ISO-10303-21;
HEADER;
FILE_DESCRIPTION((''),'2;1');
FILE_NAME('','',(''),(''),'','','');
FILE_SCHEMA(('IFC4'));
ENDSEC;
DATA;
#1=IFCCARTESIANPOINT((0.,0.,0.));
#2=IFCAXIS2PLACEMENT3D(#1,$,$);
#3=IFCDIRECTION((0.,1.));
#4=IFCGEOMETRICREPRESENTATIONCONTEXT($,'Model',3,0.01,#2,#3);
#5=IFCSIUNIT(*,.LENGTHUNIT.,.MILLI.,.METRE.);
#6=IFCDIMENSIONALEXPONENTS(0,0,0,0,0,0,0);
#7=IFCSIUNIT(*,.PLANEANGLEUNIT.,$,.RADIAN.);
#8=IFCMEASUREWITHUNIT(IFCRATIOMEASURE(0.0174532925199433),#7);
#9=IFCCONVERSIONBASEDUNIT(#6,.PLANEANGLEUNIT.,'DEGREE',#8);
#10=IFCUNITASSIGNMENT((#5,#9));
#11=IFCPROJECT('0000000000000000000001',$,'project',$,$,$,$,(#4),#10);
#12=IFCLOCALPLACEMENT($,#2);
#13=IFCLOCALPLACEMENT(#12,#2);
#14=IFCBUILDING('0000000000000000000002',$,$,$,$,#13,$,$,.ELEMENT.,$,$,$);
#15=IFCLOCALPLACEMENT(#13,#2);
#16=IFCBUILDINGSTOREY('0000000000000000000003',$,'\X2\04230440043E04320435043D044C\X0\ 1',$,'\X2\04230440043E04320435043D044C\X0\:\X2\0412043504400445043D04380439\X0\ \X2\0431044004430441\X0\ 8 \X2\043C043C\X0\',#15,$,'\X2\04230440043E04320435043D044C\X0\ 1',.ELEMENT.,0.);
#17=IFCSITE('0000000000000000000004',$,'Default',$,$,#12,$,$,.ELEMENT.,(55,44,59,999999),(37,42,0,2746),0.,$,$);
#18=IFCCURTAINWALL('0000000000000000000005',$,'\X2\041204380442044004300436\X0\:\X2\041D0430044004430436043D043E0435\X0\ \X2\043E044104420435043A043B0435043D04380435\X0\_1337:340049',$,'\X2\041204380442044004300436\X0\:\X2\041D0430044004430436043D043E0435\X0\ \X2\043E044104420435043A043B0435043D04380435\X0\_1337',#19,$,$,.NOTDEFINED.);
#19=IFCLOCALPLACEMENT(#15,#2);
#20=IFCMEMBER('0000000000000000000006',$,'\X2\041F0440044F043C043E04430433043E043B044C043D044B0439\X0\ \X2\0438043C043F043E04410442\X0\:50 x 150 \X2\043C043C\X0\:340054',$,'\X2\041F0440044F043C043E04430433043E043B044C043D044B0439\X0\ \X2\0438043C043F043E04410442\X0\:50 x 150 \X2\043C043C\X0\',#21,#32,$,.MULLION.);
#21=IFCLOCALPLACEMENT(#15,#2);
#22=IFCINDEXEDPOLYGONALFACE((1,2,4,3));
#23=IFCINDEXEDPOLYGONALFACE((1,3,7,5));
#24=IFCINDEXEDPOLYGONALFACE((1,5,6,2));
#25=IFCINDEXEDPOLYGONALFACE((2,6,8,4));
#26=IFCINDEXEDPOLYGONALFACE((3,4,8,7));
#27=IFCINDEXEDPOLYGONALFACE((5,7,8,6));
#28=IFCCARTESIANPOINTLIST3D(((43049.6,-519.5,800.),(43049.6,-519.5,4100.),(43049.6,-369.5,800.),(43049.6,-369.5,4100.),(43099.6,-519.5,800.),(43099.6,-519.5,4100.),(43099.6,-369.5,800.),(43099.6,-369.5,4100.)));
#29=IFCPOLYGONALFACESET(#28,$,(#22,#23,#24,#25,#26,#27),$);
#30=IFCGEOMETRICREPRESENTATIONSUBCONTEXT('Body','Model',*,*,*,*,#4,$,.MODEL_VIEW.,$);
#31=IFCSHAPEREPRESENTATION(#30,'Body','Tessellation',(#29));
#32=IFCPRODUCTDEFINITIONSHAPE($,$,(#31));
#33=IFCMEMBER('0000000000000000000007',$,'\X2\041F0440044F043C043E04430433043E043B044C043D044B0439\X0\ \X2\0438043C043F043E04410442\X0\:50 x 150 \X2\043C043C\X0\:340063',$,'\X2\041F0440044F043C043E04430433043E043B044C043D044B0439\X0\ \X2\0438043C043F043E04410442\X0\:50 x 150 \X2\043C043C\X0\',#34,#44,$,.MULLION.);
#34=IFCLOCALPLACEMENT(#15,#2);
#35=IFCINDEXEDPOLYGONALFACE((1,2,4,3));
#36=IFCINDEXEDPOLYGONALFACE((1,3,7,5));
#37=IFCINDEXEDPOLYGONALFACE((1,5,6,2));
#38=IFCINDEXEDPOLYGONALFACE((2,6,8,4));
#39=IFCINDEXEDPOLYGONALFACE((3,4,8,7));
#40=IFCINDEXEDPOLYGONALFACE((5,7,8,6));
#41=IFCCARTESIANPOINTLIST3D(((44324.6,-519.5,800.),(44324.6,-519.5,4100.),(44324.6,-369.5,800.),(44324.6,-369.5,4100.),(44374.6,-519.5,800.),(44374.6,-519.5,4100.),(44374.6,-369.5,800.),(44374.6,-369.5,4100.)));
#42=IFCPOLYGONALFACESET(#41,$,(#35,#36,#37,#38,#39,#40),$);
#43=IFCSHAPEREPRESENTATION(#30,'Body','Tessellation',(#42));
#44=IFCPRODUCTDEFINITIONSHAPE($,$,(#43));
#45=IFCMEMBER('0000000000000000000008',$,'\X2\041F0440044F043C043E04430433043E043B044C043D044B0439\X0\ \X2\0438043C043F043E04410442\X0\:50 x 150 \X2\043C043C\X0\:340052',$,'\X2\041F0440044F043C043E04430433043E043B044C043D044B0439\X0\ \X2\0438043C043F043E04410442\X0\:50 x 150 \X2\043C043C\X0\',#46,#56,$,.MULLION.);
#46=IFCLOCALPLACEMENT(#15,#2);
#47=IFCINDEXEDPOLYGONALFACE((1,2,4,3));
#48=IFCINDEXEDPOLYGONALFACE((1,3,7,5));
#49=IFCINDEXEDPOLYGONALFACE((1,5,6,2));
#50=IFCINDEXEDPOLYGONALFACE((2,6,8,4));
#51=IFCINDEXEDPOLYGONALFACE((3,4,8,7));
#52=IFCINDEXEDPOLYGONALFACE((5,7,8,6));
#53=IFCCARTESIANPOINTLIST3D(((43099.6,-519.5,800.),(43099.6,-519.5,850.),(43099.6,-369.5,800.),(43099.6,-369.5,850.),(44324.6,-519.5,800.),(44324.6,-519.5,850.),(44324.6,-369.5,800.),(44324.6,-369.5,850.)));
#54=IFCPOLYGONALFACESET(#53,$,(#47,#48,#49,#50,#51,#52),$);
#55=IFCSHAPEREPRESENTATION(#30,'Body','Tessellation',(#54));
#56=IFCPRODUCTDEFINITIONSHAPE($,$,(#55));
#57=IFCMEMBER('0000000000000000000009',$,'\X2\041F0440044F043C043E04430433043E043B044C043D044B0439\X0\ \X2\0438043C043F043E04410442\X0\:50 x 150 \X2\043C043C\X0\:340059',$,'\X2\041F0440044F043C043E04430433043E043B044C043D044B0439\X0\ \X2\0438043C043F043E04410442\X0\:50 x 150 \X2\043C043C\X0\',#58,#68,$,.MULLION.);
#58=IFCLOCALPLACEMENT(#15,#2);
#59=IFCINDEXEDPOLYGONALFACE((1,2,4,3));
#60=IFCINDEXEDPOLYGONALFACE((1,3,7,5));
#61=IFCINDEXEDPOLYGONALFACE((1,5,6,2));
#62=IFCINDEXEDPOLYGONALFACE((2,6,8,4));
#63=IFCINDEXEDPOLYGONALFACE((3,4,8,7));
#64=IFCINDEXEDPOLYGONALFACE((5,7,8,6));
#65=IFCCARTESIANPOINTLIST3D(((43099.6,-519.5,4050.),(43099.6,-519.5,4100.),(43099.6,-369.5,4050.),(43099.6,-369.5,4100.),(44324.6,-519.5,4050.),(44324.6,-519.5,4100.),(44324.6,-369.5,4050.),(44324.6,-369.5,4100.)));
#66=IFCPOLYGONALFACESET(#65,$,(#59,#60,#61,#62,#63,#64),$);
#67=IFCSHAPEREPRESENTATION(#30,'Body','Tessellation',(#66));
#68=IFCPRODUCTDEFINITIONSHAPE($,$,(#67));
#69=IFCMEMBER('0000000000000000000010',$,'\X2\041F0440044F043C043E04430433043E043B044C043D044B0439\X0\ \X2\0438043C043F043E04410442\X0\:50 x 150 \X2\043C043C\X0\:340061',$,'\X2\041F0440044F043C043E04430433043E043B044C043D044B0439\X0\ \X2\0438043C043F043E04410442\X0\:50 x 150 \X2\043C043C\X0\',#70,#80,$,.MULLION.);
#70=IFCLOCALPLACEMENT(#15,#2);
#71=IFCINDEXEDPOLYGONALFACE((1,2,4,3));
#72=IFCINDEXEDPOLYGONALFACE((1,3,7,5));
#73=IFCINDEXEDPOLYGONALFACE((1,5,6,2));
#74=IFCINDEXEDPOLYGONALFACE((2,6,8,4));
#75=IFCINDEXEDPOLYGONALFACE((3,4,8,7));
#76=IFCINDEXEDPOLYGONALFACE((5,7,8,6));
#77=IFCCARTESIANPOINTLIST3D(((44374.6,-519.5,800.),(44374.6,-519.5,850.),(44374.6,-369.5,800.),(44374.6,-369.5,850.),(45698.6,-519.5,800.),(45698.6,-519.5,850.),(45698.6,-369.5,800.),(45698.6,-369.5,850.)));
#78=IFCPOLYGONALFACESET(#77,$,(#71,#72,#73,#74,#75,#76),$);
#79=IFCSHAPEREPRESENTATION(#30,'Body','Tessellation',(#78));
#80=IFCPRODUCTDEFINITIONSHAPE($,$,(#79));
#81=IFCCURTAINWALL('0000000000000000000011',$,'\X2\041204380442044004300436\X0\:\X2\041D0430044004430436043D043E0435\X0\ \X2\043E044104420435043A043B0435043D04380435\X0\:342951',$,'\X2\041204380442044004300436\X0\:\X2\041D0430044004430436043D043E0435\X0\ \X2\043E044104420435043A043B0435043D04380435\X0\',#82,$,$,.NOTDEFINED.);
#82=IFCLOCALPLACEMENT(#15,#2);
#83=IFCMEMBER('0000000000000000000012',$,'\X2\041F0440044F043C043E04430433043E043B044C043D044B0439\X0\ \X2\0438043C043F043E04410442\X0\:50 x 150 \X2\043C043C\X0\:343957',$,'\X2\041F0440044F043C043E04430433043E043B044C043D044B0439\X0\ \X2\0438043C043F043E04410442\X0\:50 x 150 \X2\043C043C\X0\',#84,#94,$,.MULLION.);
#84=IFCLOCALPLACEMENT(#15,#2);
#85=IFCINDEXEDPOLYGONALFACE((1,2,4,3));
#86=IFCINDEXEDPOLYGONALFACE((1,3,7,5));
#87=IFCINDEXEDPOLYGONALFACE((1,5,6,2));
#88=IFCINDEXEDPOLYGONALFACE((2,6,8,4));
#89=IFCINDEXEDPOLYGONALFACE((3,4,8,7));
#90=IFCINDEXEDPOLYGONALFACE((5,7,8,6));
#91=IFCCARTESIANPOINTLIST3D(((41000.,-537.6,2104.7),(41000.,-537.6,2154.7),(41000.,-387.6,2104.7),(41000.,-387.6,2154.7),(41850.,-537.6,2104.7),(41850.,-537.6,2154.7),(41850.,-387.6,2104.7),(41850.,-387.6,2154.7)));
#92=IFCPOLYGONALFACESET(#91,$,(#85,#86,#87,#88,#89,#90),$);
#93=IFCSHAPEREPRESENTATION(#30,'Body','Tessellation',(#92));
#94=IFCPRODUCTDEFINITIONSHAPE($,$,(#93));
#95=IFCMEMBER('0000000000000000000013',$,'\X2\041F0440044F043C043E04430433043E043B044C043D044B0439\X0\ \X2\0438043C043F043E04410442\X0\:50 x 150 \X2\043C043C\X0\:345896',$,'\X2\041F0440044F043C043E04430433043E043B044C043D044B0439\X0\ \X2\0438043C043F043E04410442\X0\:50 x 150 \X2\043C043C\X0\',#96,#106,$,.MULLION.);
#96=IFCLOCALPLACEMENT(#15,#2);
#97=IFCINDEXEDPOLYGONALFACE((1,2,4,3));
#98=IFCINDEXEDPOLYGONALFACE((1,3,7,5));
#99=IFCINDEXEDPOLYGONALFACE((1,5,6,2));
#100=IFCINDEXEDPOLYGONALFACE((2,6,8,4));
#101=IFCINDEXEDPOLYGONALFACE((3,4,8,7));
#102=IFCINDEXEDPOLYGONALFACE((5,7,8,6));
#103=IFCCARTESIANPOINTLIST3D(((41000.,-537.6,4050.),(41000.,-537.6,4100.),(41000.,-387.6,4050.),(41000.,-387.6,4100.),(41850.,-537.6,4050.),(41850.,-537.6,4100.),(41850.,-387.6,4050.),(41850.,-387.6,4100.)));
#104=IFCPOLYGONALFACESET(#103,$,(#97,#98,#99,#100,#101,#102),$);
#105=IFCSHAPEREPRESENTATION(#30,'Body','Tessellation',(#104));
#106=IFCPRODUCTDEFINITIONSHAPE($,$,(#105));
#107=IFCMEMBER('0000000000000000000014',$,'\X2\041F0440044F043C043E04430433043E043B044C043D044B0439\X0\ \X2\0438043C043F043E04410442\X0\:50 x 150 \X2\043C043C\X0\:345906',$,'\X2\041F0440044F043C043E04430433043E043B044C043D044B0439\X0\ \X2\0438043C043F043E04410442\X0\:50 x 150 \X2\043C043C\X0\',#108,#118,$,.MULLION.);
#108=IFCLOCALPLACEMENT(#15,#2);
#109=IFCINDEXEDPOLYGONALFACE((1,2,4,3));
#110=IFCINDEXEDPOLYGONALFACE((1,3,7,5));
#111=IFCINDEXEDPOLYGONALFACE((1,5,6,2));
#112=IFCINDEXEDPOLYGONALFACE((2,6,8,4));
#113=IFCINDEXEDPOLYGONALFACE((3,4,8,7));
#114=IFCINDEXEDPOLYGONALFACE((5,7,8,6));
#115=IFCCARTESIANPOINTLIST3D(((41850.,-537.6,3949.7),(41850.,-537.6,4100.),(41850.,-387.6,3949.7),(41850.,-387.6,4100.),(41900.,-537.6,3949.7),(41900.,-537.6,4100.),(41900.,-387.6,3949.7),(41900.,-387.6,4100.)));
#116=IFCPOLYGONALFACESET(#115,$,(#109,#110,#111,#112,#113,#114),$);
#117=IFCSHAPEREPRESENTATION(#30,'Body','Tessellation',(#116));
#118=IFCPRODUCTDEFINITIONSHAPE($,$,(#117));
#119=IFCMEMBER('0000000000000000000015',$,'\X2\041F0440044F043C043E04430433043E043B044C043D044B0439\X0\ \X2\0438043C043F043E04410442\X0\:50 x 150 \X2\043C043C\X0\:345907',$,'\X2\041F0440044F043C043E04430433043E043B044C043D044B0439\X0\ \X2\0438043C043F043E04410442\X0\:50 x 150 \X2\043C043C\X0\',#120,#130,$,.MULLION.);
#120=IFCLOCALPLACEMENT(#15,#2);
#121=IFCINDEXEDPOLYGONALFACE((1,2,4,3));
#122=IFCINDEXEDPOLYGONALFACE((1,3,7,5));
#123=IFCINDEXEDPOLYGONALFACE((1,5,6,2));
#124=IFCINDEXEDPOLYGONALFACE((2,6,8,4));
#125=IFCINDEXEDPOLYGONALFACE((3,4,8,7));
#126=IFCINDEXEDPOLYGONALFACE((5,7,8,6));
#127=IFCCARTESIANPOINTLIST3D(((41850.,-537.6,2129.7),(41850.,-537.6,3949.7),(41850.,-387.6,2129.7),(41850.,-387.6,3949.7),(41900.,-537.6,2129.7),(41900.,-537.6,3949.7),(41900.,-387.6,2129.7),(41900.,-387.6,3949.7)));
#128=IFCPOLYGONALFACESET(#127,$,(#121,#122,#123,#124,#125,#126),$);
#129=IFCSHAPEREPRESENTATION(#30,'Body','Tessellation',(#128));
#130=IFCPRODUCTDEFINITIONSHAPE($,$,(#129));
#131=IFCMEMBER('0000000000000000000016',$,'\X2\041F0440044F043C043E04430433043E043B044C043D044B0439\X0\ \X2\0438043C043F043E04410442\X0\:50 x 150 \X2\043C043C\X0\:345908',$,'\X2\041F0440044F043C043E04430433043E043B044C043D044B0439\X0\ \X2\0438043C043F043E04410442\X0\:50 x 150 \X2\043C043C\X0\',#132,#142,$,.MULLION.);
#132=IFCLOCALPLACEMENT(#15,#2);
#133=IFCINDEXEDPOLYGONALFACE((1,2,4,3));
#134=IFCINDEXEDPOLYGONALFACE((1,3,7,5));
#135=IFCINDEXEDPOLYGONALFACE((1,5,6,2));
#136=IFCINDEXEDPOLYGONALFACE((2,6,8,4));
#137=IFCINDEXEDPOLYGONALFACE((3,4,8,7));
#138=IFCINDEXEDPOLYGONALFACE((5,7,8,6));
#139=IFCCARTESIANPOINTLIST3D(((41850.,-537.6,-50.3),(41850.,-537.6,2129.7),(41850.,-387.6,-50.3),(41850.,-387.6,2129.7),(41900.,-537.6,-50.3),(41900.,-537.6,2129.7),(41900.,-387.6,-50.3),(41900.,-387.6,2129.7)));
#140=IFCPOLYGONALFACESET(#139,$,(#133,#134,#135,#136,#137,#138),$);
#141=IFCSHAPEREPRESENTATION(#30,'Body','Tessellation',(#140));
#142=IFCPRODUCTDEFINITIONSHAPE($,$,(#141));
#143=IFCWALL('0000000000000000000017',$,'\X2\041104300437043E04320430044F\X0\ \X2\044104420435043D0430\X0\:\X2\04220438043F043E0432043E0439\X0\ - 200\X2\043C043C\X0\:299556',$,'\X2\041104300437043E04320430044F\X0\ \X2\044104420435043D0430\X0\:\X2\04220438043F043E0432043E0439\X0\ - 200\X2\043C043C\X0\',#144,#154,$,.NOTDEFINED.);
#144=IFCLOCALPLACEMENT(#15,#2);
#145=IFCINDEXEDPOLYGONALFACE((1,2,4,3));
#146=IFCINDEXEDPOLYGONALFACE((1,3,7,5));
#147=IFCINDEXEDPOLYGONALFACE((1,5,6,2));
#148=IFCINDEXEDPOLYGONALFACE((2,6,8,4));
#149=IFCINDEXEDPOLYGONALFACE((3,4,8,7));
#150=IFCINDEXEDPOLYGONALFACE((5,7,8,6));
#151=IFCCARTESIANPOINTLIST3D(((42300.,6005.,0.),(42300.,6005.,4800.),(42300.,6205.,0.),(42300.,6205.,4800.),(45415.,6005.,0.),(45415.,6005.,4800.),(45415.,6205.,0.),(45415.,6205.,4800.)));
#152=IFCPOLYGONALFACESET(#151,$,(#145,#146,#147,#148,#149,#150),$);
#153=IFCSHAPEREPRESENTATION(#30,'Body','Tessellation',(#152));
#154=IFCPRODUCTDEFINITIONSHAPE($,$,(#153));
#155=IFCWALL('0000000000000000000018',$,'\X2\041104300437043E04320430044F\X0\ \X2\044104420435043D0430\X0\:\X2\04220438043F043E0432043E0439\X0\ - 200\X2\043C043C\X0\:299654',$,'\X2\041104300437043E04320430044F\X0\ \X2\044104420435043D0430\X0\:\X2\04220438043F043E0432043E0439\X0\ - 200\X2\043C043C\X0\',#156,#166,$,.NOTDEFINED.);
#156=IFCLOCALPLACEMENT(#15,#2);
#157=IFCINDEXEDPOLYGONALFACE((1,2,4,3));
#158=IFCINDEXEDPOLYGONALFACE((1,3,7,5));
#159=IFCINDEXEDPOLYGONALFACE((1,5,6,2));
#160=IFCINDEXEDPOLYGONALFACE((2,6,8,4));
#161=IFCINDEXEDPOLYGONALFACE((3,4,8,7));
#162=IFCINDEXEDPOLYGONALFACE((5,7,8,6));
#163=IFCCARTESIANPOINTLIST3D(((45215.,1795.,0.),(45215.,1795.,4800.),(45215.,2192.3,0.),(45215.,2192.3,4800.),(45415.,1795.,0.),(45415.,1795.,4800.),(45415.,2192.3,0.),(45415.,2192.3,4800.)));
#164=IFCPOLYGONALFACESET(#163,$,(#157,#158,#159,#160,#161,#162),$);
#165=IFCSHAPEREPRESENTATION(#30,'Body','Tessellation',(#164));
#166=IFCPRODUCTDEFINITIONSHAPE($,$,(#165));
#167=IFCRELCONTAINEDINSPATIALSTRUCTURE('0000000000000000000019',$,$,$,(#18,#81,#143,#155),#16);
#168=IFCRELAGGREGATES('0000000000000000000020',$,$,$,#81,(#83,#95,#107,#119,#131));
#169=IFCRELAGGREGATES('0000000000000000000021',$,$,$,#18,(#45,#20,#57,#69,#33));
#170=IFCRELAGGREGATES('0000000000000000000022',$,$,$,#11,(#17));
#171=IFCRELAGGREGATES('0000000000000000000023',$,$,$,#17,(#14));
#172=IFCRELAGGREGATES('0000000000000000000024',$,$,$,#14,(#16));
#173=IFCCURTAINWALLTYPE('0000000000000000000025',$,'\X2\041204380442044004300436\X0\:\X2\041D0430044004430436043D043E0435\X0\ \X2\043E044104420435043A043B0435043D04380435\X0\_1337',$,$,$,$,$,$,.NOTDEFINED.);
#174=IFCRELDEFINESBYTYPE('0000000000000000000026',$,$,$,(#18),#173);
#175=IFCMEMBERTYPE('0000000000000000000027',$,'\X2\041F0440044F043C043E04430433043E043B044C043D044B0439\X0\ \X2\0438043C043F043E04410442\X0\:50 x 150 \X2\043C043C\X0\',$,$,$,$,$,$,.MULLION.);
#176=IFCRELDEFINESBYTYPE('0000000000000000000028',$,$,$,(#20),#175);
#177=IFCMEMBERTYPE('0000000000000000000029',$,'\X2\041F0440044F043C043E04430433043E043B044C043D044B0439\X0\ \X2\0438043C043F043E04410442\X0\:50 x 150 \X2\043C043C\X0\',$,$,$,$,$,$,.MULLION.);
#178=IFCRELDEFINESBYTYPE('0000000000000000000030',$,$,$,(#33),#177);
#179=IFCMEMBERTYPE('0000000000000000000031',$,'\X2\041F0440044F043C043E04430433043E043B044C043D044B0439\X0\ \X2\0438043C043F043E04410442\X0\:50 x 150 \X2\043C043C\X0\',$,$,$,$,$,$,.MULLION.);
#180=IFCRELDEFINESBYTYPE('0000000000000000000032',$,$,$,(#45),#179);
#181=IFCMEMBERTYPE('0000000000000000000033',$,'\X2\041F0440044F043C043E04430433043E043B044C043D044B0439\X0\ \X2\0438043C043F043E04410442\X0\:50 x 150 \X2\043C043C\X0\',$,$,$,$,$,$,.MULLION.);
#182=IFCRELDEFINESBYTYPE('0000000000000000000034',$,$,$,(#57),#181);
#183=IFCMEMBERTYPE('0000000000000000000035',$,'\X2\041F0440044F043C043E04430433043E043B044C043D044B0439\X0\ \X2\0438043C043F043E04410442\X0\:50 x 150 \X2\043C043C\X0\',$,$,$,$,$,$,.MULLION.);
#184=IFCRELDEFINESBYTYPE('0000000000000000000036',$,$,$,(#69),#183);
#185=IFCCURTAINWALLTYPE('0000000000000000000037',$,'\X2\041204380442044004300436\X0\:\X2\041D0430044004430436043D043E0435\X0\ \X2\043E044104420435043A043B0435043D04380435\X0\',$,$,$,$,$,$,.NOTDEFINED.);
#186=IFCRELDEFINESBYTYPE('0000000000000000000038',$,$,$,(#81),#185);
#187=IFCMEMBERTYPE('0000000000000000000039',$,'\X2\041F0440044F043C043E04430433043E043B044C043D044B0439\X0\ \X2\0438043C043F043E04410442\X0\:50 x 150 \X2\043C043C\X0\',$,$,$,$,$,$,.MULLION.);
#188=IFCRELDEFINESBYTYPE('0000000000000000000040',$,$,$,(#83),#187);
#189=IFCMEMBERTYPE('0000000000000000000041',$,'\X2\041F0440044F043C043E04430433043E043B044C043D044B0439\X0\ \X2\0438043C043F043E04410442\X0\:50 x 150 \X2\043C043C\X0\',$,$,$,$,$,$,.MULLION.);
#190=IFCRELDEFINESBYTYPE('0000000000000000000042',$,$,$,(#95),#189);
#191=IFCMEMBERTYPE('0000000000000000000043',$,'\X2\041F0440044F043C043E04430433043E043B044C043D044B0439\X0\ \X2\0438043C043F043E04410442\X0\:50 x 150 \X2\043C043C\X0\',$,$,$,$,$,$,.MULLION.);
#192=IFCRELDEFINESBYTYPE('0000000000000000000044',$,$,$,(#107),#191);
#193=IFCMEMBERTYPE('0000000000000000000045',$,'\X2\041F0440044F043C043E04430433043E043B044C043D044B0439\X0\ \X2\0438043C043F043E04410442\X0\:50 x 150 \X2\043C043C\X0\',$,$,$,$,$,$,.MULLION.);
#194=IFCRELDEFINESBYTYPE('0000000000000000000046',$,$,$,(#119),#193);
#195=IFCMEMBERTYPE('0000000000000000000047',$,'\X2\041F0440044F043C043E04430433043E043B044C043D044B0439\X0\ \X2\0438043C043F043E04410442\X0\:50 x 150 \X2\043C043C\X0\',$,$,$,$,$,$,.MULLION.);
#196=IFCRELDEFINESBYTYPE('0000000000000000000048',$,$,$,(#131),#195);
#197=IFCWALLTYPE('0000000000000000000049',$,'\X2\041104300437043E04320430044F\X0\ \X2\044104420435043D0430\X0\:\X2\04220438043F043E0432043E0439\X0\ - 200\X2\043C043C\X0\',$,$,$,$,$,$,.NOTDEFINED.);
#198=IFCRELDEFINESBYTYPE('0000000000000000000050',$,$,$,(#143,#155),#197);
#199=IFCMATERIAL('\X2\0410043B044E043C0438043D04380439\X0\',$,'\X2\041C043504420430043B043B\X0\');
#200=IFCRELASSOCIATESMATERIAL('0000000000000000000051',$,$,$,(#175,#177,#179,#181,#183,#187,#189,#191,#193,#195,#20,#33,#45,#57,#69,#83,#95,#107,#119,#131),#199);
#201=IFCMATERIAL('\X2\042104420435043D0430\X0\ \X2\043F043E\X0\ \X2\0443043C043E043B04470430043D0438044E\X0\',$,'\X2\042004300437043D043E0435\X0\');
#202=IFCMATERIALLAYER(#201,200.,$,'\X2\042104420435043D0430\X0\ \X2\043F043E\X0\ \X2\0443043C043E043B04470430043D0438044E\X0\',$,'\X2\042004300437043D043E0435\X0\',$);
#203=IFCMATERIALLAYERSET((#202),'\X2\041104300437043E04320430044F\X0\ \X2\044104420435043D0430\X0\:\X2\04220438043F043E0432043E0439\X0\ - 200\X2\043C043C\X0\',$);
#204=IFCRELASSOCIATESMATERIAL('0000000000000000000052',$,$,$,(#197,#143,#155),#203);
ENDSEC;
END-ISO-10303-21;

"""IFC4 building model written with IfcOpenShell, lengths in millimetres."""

from ifc_helpers import new_model, entity, si_unit, converted_unit, direction, frame, frame_2d, origin, origin_2d_with_axis, place, context, subcontext, project, spatial, rectangle, extrude, source, transform, mapped, material, layer, layer_set, layer_usage, material_profile, profile_set, profile_usage, type_object, type_shapes, element, aggregate, save


model = new_model("IFC4")

# Units and contexts
model_context = context("Model", 3, precision=0.01, world=origin(), true_north=direction((0.0, 1.0)))
body_context = subcontext(model_context, "Body", "Model", "MODEL_VIEW")
ifc_project = project(units=[si_unit("LENGTHUNIT", "METRE", prefix="MILLI"), converted_unit("PLANEANGLEUNIT", "DEGREE", entity("IfcRatioMeasure", 0.0174532925199433), si_unit("PLANEANGLEUNIT", "RADIAN"), dimensions=[0, 0, 0, 0, 0, 0, 0])], contexts=[model_context])

# Site, building, storey
site_placement = place(None, origin())
site = spatial("IfcSite", under=ifc_project, at=site_placement, Name="Default", CompositionType="ELEMENT", RefLatitude=(55, 44, 59, 999999), RefLongitude=(37, 42, 0, 2746), RefElevation=0.0)
building_placement = place(site_placement, origin())
building = spatial("IfcBuilding", under=site, at=building_placement, CompositionType="ELEMENT")
storey_placement = place(building_placement, origin())
storey = spatial("IfcBuildingStorey", under=building, at=storey_placement, Name="Уровень 1", ObjectType="Уровень:Верхний брус 8 мм", LongName="Уровень 1", CompositionType="ELEMENT", Elevation=0.0)

# Curtain walls, members
curtain_wall_type_1 = type_object("IfcCurtainWallType", Name="Витраж:Наружное остекление_1337", PredefinedType="NOTDEFINED")
curtain_wall_1_placement = place(storey_placement, origin())
curtain_wall_1 = element("IfcCurtainWall", 1, at=curtain_wall_1_placement, inside=storey, type_object=curtain_wall_type_1, Name="Витраж:Наружное остекление_1337:340049", ObjectType="Витраж:Наружное остекление_1337", PredefinedType="NOTDEFINED")
ifc_material_1 = material(Name="Алюминий", Category="Металл")
ifc_material_profile = material_profile(ifc_material_1, rectangle(XDim=150.0, YDim=50.0, at=origin_2d_with_axis()), Name="50 x 150 мм")
ifc_profile_set = profile_set([ifc_material_profile], Name="50 x 150 мм")
ifc_profile_usage_1 = profile_usage(ifc_profile_set)
member_type_1 = type_object("IfcMemberType", Name="Прямоугольный импост:50 x 150 мм", PredefinedType="MULLION", material=ifc_profile_set)
shared_shape_1 = source(origin(), body_context, "Body", "SweptSolid", [
    extrude(rectangle(XDim=150.0, YDim=50.0, at=origin_2d_with_axis()), frame((-25.0, 0.0, -3300.0), z_axis=(0.0, 0.0, 1.0), x_axis=(0.0, -1.0, 0.0)), (0.0, 0.0, 1.0), 3300.0),
])
type_shapes(member_type_1, [shared_shape_1])
member_1_placement = place(storey_placement, frame((43049.6, -444.5, 4100.0), z_axis=(0.0, 0.0, 1.0), x_axis=(-1.0, 0.0, 0.0)))
member_1 = element("IfcMember", 2, at=member_1_placement, type_object=member_type_1, material=ifc_profile_usage_1, Name="Прямоугольный импост:50 x 150 мм:340054", ObjectType="Прямоугольный импост:50 x 150 мм", PredefinedType="MULLION", context=body_context, shape_type="MappedRepresentation", body=[
    mapped(shared_shape_1, transform((0.0, 0.0, 0.0), scale=1.0)),
])
ifc_profile_usage_2 = profile_usage(ifc_profile_set)
member_type_2 = type_object("IfcMemberType", Name="Прямоугольный импост:50 x 150 мм", PredefinedType="MULLION", material=ifc_profile_set)
shared_shape_2 = source(origin(), body_context, "Body", "SweptSolid", [
    extrude(rectangle(XDim=150.0, YDim=50.0, at=origin_2d_with_axis()), frame((0.0, 0.0, -3300.0), z_axis=(0.0, 0.0, 1.0), x_axis=(0.0, -1.0, 0.0)), (0.0, 0.0, 1.0), 3300.0),
])
type_shapes(member_type_2, [shared_shape_2])
member_2_placement = place(storey_placement, frame((44349.6, -444.5, 800.0), z_axis=(0.0, 0.0, -1.0), x_axis=(1.0, 0.0, 0.0)))
member_2 = element("IfcMember", 3, at=member_2_placement, type_object=member_type_2, material=ifc_profile_usage_2, Name="Прямоугольный импост:50 x 150 мм:340063", ObjectType="Прямоугольный импост:50 x 150 мм", PredefinedType="MULLION", context=body_context, shape_type="MappedRepresentation", body=[
    mapped(shared_shape_2, transform((0.0, 0.0, 0.0), scale=1.0)),
])
ifc_profile_usage_3 = profile_usage(ifc_profile_set)
member_type_3 = type_object("IfcMemberType", Name="Прямоугольный импост:50 x 150 мм", PredefinedType="MULLION", material=ifc_profile_set)
shared_shape_3 = source(origin(), body_context, "Body", "SweptSolid", [
    extrude(rectangle(XDim=150.0, YDim=50.0, at=origin_2d_with_axis()), frame((-25.0, 0.0, -1225.0), z_axis=(0.0, 0.0, 1.0), x_axis=(0.0, -1.0, 0.0)), (0.0, 0.0, 1.0), 1225.0),
])
type_shapes(member_type_3, [shared_shape_3])
member_3_placement = place(storey_placement, frame((43099.6, -444.5, 800.0), z_axis=(-1.0, 0.0, 0.0), x_axis=(0.0, 0.0, -1.0)))
member_3 = element("IfcMember", 4, at=member_3_placement, type_object=member_type_3, material=ifc_profile_usage_3, Name="Прямоугольный импост:50 x 150 мм:340052", ObjectType="Прямоугольный импост:50 x 150 мм", PredefinedType="MULLION", context=body_context, shape_type="MappedRepresentation", body=[
    mapped(shared_shape_3, transform((0.0, 0.0, 0.0), scale=1.0)),
])
ifc_profile_usage_4 = profile_usage(ifc_profile_set)
member_type_4 = type_object("IfcMemberType", Name="Прямоугольный импост:50 x 150 мм", PredefinedType="MULLION", material=ifc_profile_set)
shared_shape_4 = source(origin(), body_context, "Body", "SweptSolid", [
    extrude(rectangle(XDim=150.0, YDim=50.0, at=origin_2d_with_axis()), frame((-25.0, 0.0, -1225.0), z_axis=(0.0, 0.0, 1.0), x_axis=(0.0, -1.0, 0.0)), (0.0, 0.0, 1.0), 1225.0),
])
type_shapes(member_type_4, [shared_shape_4])
member_4_placement = place(storey_placement, frame((44324.6, -444.5, 4100.0), z_axis=(1.0, 0.0, 0.0), x_axis=(0.0, 0.0, 1.0)))
member_4 = element("IfcMember", 5, at=member_4_placement, type_object=member_type_4, material=ifc_profile_usage_4, Name="Прямоугольный импост:50 x 150 мм:340059", ObjectType="Прямоугольный импост:50 x 150 мм", PredefinedType="MULLION", context=body_context, shape_type="MappedRepresentation", body=[
    mapped(shared_shape_4, transform((0.0, 0.0, 0.0), scale=1.0)),
])
ifc_profile_usage_5 = profile_usage(ifc_profile_set)
member_type_5 = type_object("IfcMemberType", Name="Прямоугольный импост:50 x 150 мм", PredefinedType="MULLION", material=ifc_profile_set)
shared_shape_5 = source(origin(), body_context, "Body", "SweptSolid", [
    extrude(rectangle(XDim=150.0, YDim=50.0, at=origin_2d_with_axis()), frame((-25.0, 0.0, -1324.0), z_axis=(0.0, 0.0, 1.0), x_axis=(0.0, -1.0, 0.0)), (0.0, 0.0, 1.0), 1324.0),
])
type_shapes(member_type_5, [shared_shape_5])
member_5_placement = place(storey_placement, frame((44374.6, -444.5, 800.0), z_axis=(-1.0, 0.0, 0.0), x_axis=(0.0, 0.0, -1.0)))
member_5 = element("IfcMember", 6, at=member_5_placement, type_object=member_type_5, material=ifc_profile_usage_5, Name="Прямоугольный импост:50 x 150 мм:340061", ObjectType="Прямоугольный импост:50 x 150 мм", PredefinedType="MULLION", context=body_context, shape_type="MappedRepresentation", body=[
    mapped(shared_shape_5, transform((0.0, 0.0, 0.0), scale=1.0)),
])
curtain_wall_type_2 = type_object("IfcCurtainWallType", Name="Витраж:Наружное остекление", PredefinedType="NOTDEFINED")
curtain_wall_2_placement = place(storey_placement, origin())
curtain_wall_2 = element("IfcCurtainWall", 7, at=curtain_wall_2_placement, inside=storey, type_object=curtain_wall_type_2, Name="Витраж:Наружное остекление:342951", ObjectType="Витраж:Наружное остекление", PredefinedType="NOTDEFINED")
ifc_profile_usage_6 = profile_usage(ifc_profile_set)
member_type_6 = type_object("IfcMemberType", Name="Прямоугольный импост:50 x 150 мм", PredefinedType="MULLION", material=ifc_profile_set)
shared_shape_6 = source(origin(), body_context, "Body", "SweptSolid", [
    extrude(rectangle(XDim=150.0, YDim=50.0, at=origin_2d_with_axis()), frame((0.0, 0.0, -850.0), z_axis=(0.0, 0.0, 1.0), x_axis=(0.0, -1.0, 0.0)), (0.0, 0.0, 1.0), 850.0),
])
type_shapes(member_type_6, [shared_shape_6])
member_6_placement = place(storey_placement, frame((41850.0, -462.6, 2129.7), z_axis=(1.0, 0.0, 0.0), x_axis=(0.0, 0.0, 1.0)))
member_6 = element("IfcMember", 8, at=member_6_placement, type_object=member_type_6, material=ifc_profile_usage_6, Name="Прямоугольный импост:50 x 150 мм:343957", ObjectType="Прямоугольный импост:50 x 150 мм", PredefinedType="MULLION", context=body_context, shape_type="MappedRepresentation", body=[
    mapped(shared_shape_6, transform((0.0, 0.0, 0.0), scale=1.0)),
])
ifc_profile_usage_7 = profile_usage(ifc_profile_set)
member_type_7 = type_object("IfcMemberType", Name="Прямоугольный импост:50 x 150 мм", PredefinedType="MULLION", material=ifc_profile_set)
shared_shape_7 = source(origin(), body_context, "Body", "SweptSolid", [
    extrude(rectangle(XDim=150.0, YDim=50.0, at=origin_2d_with_axis()), frame((-25.0, 0.0, -850.0), z_axis=(0.0, 0.0, 1.0), x_axis=(0.0, -1.0, 0.0)), (0.0, 0.0, 1.0), 850.0),
])
type_shapes(member_type_7, [shared_shape_7])
member_7_placement = place(storey_placement, frame((41850.0, -462.6, 4100.0), z_axis=(1.0, 0.0, 0.0), x_axis=(0.0, 0.0, 1.0)))
member_7 = element("IfcMember", 9, at=member_7_placement, type_object=member_type_7, material=ifc_profile_usage_7, Name="Прямоугольный импост:50 x 150 мм:345896", ObjectType="Прямоугольный импост:50 x 150 мм", PredefinedType="MULLION", context=body_context, shape_type="MappedRepresentation", body=[
    mapped(shared_shape_7, transform((0.0, 0.0, 0.0), scale=1.0)),
])
ifc_profile_usage_8 = profile_usage(ifc_profile_set)
member_type_8 = type_object("IfcMemberType", Name="Прямоугольный импост:50 x 150 мм", PredefinedType="MULLION", material=ifc_profile_set)
shared_shape_8 = source(origin(), body_context, "Body", "SweptSolid", [
    extrude(rectangle(XDim=150.0, YDim=50.0, at=origin_2d_with_axis()), frame((-25.0, 0.0, -150.3), z_axis=(0.0, 0.0, 1.0), x_axis=(0.0, -1.0, 0.0)), (0.0, 0.0, 1.0), 150.3),
])
type_shapes(member_type_8, [shared_shape_8])
member_8_placement = place(storey_placement, frame((41900.0, -462.6, 3949.7), z_axis=(0.0, 0.0, -1.0), x_axis=(1.0, 0.0, 0.0)))
member_8 = element("IfcMember", 10, at=member_8_placement, type_object=member_type_8, material=ifc_profile_usage_8, Name="Прямоугольный импост:50 x 150 мм:345906", ObjectType="Прямоугольный импост:50 x 150 мм", PredefinedType="MULLION", context=body_context, shape_type="MappedRepresentation", body=[
    mapped(shared_shape_8, transform((0.0, 0.0, 0.0), scale=1.0)),
])
ifc_profile_usage_9 = profile_usage(ifc_profile_set)
member_type_9 = type_object("IfcMemberType", Name="Прямоугольный импост:50 x 150 мм", PredefinedType="MULLION", material=ifc_profile_set)
shared_shape_9 = source(origin(), body_context, "Body", "SweptSolid", [
    extrude(rectangle(XDim=150.0, YDim=50.0, at=origin_2d_with_axis()), frame((-25.0, 0.0, -1820.0), z_axis=(0.0, 0.0, 1.0), x_axis=(0.0, -1.0, 0.0)), (0.0, 0.0, 1.0), 1820.0),
])
type_shapes(member_type_9, [shared_shape_9])
member_9_placement = place(storey_placement, frame((41900.0, -462.6, 2129.7), z_axis=(0.0, 0.0, -1.0), x_axis=(1.0, 0.0, 0.0)))
member_9 = element("IfcMember", 11, at=member_9_placement, type_object=member_type_9, material=ifc_profile_usage_9, Name="Прямоугольный импост:50 x 150 мм:345907", ObjectType="Прямоугольный импост:50 x 150 мм", PredefinedType="MULLION", context=body_context, shape_type="MappedRepresentation", body=[
    mapped(shared_shape_9, transform((0.0, 0.0, 0.0), scale=1.0)),
])
ifc_profile_usage_10 = profile_usage(ifc_profile_set)
member_type_10 = type_object("IfcMemberType", Name="Прямоугольный импост:50 x 150 мм", PredefinedType="MULLION", material=ifc_profile_set)
shared_shape_10 = source(origin(), body_context, "Body", "SweptSolid", [
    extrude(rectangle(XDim=150.0, YDim=50.0, at=origin_2d_with_axis()), frame((-25.0, 0.0, -2180.0), z_axis=(0.0, 0.0, 1.0), x_axis=(0.0, -1.0, 0.0)), (0.0, 0.0, 1.0), 2180.0),
])
type_shapes(member_type_10, [shared_shape_10])
member_10_placement = place(storey_placement, frame((41900.0, -462.6, -50.3), z_axis=(0.0, 0.0, -1.0), x_axis=(1.0, 0.0, 0.0)))
member_10 = element("IfcMember", 12, at=member_10_placement, type_object=member_type_10, material=ifc_profile_usage_10, Name="Прямоугольный импост:50 x 150 мм:345908", ObjectType="Прямоугольный импост:50 x 150 мм", PredefinedType="MULLION", context=body_context, shape_type="MappedRepresentation", body=[
    mapped(shared_shape_10, transform((0.0, 0.0, 0.0), scale=1.0)),
])
aggregate(curtain_wall_2, [member_6, member_7, member_8, member_9, member_10])

aggregate(curtain_wall_1, [member_3, member_1, member_4, member_5, member_2])

# Wall
ifc_material_2 = material(Name="Стена по умолчанию", Category="Разное")
ifc_layer_1 = layer(ifc_material_2, 200.0, Name="Стена по умолчанию", Category="Разное")
ifc_layer_set_1 = layer_set([ifc_layer_1], Name="Базовая стена:Типовой - 200мм")
ifc_layer_usage_1 = layer_usage(ifc_layer_set_1, "AXIS2", "NEGATIVE", 100.0)
wall_type_1 = type_object("IfcWallType", Name="Базовая стена:Типовой - 200мм", PredefinedType="NOTDEFINED", material=ifc_layer_set_1)
wall_1_placement = place(storey_placement, frame((42300.0, 6105.0, 0.0)))
element("IfcWall", 13, at=wall_1_placement, inside=storey, type_object=wall_type_1, material=ifc_layer_usage_1, Name="Базовая стена:Типовой - 200мм:299556", ObjectType="Базовая стена:Типовой - 200мм", PredefinedType="NOTDEFINED", context=body_context, shape_type="SweptSolid", body=[
    extrude(rectangle(XDim=3115.0, YDim=200.0, at=frame_2d((1557.5, 0.0), x_axis=(-1.0, 0.0))), origin(), (0.0, 0.0, 1.0), 4800.0),
])

# Wall
ifc_layer_usage_2 = layer_usage(ifc_layer_set_1, "AXIS2", "NEGATIVE", 100.0)
wall_2_placement = place(storey_placement, frame((45315.0, 2192.3, 0.0), z_axis=(0.0, 0.0, 1.0), x_axis=(0.0, -1.0, 0.0)))
element("IfcWall", 14, at=wall_2_placement, inside=storey, type_object=wall_type_1, material=ifc_layer_usage_2, Name="Базовая стена:Типовой - 200мм:299654", ObjectType="Базовая стена:Типовой - 200мм", PredefinedType="NOTDEFINED", context=body_context, shape_type="SweptSolid", body=[
    extrude(rectangle(XDim=397.3, YDim=200.0, at=frame_2d((198.6, 0.0), x_axis=(-1.0, 0.0))), origin(), (0.0, 0.0, 1.0), 4800.0),
])

save(model, "model.ifc")
